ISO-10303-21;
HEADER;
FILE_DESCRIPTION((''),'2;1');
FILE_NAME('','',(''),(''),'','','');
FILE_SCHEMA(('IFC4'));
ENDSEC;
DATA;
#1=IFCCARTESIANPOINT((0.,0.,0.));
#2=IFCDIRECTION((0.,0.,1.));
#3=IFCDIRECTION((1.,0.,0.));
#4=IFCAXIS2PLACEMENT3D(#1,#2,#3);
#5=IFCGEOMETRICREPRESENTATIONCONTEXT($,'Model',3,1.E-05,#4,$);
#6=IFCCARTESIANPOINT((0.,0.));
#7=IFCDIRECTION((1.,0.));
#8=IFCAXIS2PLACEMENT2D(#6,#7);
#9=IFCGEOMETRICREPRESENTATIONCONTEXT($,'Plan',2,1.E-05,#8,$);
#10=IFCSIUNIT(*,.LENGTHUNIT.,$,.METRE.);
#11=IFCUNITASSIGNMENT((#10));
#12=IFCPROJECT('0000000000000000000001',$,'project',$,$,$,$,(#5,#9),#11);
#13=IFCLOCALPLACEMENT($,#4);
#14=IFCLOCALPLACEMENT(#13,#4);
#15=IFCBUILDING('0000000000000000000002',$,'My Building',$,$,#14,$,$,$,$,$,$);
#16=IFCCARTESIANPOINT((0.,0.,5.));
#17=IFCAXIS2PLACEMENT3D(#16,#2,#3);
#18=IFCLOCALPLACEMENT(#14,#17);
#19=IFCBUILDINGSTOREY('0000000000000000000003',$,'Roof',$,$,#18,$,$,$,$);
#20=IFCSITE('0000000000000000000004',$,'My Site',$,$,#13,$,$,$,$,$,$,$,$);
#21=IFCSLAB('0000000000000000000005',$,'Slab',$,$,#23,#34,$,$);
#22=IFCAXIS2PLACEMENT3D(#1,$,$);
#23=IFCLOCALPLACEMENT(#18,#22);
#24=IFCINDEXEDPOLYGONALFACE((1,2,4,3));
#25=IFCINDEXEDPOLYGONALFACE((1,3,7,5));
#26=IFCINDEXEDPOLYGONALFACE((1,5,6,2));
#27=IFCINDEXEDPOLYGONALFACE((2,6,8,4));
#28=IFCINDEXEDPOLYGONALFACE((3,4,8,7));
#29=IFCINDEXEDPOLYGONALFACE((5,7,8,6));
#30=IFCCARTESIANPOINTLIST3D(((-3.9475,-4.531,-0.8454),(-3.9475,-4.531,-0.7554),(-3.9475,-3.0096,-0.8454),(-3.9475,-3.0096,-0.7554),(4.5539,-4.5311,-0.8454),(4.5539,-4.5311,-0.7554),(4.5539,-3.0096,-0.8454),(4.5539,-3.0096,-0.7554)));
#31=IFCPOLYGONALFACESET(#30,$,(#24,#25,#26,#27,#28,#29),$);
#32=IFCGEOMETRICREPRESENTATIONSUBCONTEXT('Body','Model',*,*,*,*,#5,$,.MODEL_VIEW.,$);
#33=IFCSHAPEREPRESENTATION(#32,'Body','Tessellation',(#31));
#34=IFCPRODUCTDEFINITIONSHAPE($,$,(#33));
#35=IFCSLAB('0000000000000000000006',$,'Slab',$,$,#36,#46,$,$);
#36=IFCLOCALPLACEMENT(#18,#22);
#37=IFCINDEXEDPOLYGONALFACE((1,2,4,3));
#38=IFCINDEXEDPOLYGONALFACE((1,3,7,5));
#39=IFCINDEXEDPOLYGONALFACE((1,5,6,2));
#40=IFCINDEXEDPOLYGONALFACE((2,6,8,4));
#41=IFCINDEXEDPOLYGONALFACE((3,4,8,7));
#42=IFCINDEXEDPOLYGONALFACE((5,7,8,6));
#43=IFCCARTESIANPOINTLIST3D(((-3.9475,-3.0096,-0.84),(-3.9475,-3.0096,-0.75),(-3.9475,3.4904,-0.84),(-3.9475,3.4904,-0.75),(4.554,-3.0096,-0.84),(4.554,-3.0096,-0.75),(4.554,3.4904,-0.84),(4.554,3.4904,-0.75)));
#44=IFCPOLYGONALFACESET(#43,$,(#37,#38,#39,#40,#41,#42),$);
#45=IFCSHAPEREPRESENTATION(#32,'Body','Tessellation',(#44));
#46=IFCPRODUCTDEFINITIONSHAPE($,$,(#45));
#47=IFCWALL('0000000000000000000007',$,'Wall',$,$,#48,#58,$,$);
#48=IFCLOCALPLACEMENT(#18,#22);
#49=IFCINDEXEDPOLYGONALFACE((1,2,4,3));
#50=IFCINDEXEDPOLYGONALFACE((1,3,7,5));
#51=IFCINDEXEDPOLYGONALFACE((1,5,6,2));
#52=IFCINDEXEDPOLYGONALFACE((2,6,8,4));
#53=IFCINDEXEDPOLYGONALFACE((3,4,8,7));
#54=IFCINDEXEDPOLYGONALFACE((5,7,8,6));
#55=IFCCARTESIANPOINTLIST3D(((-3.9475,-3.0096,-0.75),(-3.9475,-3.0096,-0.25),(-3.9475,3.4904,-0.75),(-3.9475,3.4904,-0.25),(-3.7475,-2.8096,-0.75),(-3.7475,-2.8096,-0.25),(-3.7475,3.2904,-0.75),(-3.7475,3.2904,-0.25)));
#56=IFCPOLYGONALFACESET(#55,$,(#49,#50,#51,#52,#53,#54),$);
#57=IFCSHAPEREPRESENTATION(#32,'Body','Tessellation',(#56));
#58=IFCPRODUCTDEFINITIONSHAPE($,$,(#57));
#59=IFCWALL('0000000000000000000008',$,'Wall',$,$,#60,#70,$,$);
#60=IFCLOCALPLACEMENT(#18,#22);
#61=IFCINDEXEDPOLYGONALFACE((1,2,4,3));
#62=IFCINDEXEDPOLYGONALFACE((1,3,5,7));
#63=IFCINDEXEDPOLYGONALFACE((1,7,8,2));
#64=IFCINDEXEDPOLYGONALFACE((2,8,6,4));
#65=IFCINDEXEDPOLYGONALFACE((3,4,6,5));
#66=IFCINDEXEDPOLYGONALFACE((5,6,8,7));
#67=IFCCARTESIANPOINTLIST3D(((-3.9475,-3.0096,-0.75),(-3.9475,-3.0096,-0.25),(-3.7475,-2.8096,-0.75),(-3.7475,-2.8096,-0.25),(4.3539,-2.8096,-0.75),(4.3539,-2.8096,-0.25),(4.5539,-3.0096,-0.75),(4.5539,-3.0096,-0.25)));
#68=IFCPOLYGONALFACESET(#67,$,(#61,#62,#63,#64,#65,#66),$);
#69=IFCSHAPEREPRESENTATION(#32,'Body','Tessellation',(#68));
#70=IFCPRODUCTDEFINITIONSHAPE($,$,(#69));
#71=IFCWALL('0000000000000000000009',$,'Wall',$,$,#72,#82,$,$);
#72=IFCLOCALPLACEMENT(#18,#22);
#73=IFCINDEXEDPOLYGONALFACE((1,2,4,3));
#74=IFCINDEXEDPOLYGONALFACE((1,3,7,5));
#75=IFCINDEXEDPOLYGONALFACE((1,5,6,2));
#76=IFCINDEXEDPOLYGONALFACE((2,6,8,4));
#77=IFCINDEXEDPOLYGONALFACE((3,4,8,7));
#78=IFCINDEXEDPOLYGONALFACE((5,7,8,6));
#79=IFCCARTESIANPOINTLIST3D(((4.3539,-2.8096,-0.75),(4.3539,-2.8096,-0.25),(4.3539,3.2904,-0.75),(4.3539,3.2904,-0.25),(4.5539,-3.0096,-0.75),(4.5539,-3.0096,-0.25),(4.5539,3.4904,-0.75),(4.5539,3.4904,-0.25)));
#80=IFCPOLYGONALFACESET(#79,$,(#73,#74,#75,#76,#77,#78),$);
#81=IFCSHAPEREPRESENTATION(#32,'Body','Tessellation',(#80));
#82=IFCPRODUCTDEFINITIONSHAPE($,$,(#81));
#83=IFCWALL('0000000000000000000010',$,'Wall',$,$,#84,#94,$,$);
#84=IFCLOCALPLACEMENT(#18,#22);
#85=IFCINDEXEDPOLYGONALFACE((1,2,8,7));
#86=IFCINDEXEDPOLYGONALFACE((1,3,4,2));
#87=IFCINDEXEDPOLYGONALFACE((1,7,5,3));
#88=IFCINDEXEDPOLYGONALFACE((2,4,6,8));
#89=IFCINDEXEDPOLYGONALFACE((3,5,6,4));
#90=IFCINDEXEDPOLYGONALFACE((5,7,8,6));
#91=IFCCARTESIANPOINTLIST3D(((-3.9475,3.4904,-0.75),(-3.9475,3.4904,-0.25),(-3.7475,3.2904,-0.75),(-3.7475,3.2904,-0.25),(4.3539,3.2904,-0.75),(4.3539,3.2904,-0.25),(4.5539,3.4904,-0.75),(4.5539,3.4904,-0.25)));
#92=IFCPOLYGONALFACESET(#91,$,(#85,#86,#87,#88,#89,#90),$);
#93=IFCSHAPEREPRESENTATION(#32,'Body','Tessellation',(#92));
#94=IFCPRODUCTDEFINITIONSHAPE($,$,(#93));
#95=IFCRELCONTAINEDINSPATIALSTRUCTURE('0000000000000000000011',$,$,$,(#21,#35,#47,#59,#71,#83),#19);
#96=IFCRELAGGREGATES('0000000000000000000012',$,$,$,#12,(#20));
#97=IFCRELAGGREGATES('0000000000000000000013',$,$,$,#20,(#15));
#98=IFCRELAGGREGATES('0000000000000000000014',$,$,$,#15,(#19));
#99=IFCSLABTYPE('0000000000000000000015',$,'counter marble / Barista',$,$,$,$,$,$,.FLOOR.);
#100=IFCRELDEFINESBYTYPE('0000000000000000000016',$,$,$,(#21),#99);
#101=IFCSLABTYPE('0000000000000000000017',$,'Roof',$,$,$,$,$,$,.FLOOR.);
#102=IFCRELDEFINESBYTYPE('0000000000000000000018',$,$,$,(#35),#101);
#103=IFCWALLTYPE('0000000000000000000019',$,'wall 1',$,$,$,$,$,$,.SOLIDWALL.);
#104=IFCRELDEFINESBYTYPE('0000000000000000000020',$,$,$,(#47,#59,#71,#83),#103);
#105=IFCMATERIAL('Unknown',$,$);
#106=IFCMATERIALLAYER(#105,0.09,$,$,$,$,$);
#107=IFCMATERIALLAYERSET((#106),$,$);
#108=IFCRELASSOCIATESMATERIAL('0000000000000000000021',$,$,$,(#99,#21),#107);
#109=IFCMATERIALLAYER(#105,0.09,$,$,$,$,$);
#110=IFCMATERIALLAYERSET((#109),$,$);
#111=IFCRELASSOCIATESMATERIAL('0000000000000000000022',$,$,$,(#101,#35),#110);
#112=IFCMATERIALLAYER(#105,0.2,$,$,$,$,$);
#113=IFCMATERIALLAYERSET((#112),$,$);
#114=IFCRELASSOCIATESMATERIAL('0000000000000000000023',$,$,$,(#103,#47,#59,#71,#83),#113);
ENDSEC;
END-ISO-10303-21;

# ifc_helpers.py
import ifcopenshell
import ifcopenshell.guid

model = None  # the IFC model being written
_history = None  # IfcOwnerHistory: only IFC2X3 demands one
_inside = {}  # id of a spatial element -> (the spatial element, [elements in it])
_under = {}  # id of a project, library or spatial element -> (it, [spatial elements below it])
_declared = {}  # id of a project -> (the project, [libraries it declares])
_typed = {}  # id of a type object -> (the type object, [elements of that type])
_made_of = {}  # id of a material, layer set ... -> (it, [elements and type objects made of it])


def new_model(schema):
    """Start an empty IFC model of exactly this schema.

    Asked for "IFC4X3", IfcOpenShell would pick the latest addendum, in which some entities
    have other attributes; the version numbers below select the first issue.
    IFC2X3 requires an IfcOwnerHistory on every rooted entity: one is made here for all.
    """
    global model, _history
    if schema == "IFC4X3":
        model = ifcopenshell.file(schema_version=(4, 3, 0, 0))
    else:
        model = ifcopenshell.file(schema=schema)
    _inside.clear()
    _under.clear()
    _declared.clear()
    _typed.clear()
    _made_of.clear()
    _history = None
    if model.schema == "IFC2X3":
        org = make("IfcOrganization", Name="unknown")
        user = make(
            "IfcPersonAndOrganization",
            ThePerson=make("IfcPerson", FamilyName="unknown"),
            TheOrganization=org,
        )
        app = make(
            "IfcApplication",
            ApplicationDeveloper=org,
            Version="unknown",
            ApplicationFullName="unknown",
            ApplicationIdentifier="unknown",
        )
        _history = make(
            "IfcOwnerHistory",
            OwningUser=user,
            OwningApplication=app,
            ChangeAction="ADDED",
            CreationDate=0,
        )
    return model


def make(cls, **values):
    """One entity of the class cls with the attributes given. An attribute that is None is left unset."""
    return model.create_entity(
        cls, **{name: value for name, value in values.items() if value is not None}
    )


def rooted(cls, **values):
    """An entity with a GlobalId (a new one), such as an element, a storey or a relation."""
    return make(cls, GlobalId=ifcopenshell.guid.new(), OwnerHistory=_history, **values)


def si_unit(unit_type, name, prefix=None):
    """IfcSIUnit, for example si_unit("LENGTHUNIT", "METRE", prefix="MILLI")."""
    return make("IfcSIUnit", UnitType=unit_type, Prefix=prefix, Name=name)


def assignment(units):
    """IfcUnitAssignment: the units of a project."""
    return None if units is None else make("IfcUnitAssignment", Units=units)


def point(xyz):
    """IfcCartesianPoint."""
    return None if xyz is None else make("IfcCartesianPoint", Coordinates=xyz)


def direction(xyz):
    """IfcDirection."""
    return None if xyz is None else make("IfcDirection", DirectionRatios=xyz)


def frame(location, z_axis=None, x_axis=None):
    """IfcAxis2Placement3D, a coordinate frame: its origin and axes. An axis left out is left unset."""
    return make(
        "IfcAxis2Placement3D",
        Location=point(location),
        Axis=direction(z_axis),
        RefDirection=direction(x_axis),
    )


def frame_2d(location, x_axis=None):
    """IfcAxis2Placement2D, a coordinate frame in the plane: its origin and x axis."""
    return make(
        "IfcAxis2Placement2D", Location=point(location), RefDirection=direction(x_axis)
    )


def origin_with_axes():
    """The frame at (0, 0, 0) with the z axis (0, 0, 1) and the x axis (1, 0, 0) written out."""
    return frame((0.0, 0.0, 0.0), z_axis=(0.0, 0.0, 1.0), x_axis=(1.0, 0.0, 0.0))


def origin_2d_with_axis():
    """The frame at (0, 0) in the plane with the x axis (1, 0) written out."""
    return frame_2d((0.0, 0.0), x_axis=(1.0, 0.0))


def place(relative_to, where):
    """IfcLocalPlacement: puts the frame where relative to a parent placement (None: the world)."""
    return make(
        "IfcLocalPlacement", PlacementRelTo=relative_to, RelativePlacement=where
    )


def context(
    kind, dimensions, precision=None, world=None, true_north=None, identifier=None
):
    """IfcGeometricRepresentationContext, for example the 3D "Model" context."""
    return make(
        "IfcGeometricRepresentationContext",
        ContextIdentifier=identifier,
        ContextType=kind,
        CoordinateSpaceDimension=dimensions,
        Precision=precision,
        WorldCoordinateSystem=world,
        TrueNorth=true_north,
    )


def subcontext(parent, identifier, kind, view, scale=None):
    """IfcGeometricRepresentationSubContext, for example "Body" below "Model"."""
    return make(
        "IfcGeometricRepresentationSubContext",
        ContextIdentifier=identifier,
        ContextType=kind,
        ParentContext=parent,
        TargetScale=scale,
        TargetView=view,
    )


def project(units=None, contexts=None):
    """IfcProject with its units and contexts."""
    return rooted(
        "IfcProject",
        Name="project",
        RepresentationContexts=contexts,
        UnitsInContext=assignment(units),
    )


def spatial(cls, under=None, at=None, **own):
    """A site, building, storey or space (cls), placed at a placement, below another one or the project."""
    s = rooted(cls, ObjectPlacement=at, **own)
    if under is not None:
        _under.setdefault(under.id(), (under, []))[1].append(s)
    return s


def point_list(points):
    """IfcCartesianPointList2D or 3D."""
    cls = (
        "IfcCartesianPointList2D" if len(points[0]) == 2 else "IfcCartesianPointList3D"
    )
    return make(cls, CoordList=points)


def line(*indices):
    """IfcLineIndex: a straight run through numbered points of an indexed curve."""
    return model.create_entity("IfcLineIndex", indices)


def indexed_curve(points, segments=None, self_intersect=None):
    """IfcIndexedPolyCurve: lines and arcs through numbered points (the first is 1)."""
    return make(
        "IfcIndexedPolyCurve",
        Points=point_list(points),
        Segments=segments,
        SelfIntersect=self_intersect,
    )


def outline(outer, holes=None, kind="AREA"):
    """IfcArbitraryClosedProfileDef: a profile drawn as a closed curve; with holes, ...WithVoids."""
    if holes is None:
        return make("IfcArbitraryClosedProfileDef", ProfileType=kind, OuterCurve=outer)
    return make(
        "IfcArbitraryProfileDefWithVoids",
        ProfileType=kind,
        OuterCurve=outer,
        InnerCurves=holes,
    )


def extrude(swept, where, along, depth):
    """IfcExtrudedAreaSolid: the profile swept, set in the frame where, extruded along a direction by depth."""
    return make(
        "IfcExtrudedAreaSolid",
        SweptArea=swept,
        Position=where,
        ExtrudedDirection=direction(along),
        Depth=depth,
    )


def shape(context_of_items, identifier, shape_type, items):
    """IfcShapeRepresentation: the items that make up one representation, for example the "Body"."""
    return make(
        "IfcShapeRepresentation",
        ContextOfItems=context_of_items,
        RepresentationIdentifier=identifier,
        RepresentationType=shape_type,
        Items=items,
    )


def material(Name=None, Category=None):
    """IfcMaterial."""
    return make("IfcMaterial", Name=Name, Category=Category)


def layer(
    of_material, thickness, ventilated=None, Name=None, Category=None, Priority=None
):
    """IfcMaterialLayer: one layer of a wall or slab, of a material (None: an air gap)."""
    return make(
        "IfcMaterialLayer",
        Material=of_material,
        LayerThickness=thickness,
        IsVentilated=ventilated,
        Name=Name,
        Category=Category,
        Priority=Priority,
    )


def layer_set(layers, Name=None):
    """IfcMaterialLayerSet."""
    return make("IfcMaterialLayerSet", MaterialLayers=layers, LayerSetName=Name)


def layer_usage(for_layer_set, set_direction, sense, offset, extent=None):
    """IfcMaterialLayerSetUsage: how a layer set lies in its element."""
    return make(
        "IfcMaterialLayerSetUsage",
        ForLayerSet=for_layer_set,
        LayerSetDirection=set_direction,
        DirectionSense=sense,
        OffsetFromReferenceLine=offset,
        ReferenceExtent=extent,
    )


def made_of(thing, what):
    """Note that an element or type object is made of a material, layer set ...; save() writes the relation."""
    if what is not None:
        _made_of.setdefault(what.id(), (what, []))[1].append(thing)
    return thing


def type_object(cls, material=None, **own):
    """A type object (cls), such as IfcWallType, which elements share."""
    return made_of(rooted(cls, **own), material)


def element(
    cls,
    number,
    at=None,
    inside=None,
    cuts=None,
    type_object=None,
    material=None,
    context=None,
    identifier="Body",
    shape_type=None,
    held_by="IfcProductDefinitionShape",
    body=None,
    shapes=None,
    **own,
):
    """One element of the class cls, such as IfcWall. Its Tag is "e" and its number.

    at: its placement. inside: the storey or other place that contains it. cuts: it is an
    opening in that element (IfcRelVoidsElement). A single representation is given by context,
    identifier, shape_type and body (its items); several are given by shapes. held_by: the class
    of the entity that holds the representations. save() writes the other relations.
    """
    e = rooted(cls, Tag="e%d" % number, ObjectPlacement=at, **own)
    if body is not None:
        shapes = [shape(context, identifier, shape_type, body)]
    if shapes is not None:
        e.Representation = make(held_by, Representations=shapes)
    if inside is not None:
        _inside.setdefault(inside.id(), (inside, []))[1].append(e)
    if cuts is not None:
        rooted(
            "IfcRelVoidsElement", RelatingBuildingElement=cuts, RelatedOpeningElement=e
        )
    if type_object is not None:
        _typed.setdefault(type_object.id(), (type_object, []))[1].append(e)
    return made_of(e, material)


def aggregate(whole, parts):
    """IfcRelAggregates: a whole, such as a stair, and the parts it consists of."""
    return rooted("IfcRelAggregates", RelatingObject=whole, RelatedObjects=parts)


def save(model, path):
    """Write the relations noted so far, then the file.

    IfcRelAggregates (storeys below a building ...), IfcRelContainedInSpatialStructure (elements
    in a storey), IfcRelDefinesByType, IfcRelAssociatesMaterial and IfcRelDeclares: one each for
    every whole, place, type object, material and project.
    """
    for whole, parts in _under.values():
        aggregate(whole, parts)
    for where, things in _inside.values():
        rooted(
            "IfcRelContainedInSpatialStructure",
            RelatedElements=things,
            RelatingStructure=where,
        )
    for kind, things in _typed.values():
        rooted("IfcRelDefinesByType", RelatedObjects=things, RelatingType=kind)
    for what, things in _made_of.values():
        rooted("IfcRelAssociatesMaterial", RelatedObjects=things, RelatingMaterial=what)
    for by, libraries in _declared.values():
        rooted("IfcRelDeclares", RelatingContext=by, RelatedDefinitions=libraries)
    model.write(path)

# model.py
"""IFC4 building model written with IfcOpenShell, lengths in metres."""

from ifc_helpers import new_model, si_unit, frame, origin_with_axes, origin_2d_with_axis, place, context, subcontext, project, spatial, line, indexed_curve, outline, extrude, material, layer, layer_set, layer_usage, type_object, element, save


model = new_model("IFC4")

# Units and contexts
model_context = context("Model", 3, precision=1e-05, world=origin_with_axes())
plan_context = context("Plan", 2, precision=1e-05, world=origin_2d_with_axis())
body_context = subcontext(model_context, "Body", "Model", "MODEL_VIEW")
ifc_project = project(units=[si_unit("LENGTHUNIT", "METRE")], contexts=[model_context, plan_context])

# Site, building, storey
site_placement = place(None, origin_with_axes())
site = spatial("IfcSite", under=ifc_project, at=site_placement, Name="My Site")
building_placement = place(site_placement, origin_with_axes())
building = spatial("IfcBuilding", under=site, at=building_placement, Name="My Building")
storey_placement = place(building_placement, frame((0.0, 0.0, 5.0), z_axis=(0.0, 0.0, 1.0), x_axis=(1.0, 0.0, 0.0)))
storey = spatial("IfcBuildingStorey", under=building, at=storey_placement, Name="Roof")

# Slabs
ifc_material = material(Name="Unknown")
ifc_layer_1 = layer(ifc_material, 0.09)
ifc_layer_set_1 = layer_set([ifc_layer_1])
ifc_layer_usage_1 = layer_usage(ifc_layer_set_1, "AXIS3", "POSITIVE", -0.09)
slab_type_1 = type_object("IfcSlabType", Name="counter marble / Barista", PredefinedType="FLOOR", material=ifc_layer_set_1)
slab_1_placement = place(storey_placement, frame((-3.9475, -4.531, -0.7554), z_axis=(0.0, 0.0, 1.0), x_axis=(1.0, 0.0, 0.0)))
element("IfcSlab", 1, at=slab_1_placement, inside=storey, type_object=slab_type_1, material=ifc_layer_usage_1, Name="Slab", context=body_context, shape_type="SweptSolid", body=[
    extrude(outline(indexed_curve([(0.0, 0.0), (0.0, 1.5214), (8.5014, 1.5214), (8.5014, -0.0001), (0.0, 0.0)])), frame((0.0, 0.0, -0.09), z_axis=(0.0, 0.0, 1.0), x_axis=(1.0, 0.0, 0.0)), (0.0, 0.0, 1.0), 0.09),
])
ifc_layer_2 = layer(ifc_material, 0.09)
ifc_layer_set_2 = layer_set([ifc_layer_2])
ifc_layer_usage_2 = layer_usage(ifc_layer_set_2, "AXIS3", "POSITIVE", -0.09)
slab_type_2 = type_object("IfcSlabType", Name="Roof", PredefinedType="FLOOR", material=ifc_layer_set_2)
slab_2_placement = place(storey_placement, frame((-3.9475, 3.4904, -0.75), z_axis=(0.0, 0.0, 1.0), x_axis=(1.0, 0.0, 0.0)))
element("IfcSlab", 2, at=slab_2_placement, inside=storey, type_object=slab_type_2, material=ifc_layer_usage_2, Name="Slab", context=body_context, shape_type="SweptSolid", body=[
    extrude(outline(indexed_curve([(0.0, 0.0), (0.0, -6.5), (8.5015, -6.5), (8.5015, 0.0), (0.0, 0.0)])), frame((0.0, 0.0, -0.09), z_axis=(0.0, 0.0, 1.0), x_axis=(1.0, 0.0, 0.0)), (0.0, 0.0, 1.0), 0.09),
])

# Walls
ifc_layer_3 = layer(ifc_material, 0.2)
ifc_layer_set_3 = layer_set([ifc_layer_3])
ifc_layer_usage_3 = layer_usage(ifc_layer_set_3, "AXIS2", "POSITIVE", 0.0)
wall_type = type_object("IfcWallType", Name="wall 1", PredefinedType="SOLIDWALL", material=ifc_layer_set_3)
wall_1_placement = place(storey_placement, frame((-3.9475, 3.4904, -0.75), z_axis=(0.0, 0.0, 1.0), x_axis=(0.0, -1.0, 0.0)))
element("IfcWall", 3, at=wall_1_placement, inside=storey, type_object=wall_type, material=ifc_layer_usage_3, Name="Wall", context=body_context, shape_type="SweptSolid", body=[
    extrude(outline(indexed_curve([(0.0, 0.0), (0.2, 0.2), (6.3, 0.2), (6.5, 0.0)], segments=[line(1, 2, 3, 4, 1)])), origin_with_axes(), (0.0, 0.0, 1.0), 0.5),
])
ifc_layer_usage_4 = layer_usage(ifc_layer_set_3, "AXIS2", "POSITIVE", 0.0)
wall_2_placement = place(storey_placement, frame((-3.9475, -3.0096, -0.75), z_axis=(0.0, 0.0, 1.0), x_axis=(1.0, 0.0, 0.0)))
element("IfcWall", 4, at=wall_2_placement, inside=storey, type_object=wall_type, material=ifc_layer_usage_4, Name="Wall", context=body_context, shape_type="SweptSolid", body=[
    extrude(outline(indexed_curve([(0.0, 0.0), (0.2, 0.2), (8.3014, 0.2), (8.5014, 0.0)], segments=[line(1, 2, 3, 4, 1)])), origin_with_axes(), (0.0, 0.0, 1.0), 0.5),
])
ifc_layer_usage_5 = layer_usage(ifc_layer_set_3, "AXIS2", "POSITIVE", 0.0)
wall_3_placement = place(storey_placement, frame((4.5539, -3.0096, -0.75), z_axis=(0.0, 0.0, 1.0), x_axis=(0.0, 1.0, 0.0)))
element("IfcWall", 5, at=wall_3_placement, inside=storey, type_object=wall_type, material=ifc_layer_usage_5, Name="Wall", context=body_context, shape_type="SweptSolid", body=[
    extrude(outline(indexed_curve([(0.0, 0.0), (0.2, 0.2), (6.3, 0.2), (6.5, 0.0)], segments=[line(1, 2, 3, 4, 1)])), origin_with_axes(), (0.0, 0.0, 1.0), 0.5),
])
ifc_layer_usage_6 = layer_usage(ifc_layer_set_3, "AXIS2", "POSITIVE", 0.0)
wall_4_placement = place(storey_placement, frame((4.5539, 3.4904, -0.75), z_axis=(0.0, 0.0, 1.0), x_axis=(-1.0, 0.0, 0.0)))
element("IfcWall", 6, at=wall_4_placement, inside=storey, type_object=wall_type, material=ifc_layer_usage_6, Name="Wall", context=body_context, shape_type="SweptSolid", body=[
    extrude(outline(indexed_curve([(0.0, 0.0), (0.2, 0.2), (8.3014, 0.2), (8.5014, 0.0)], segments=[line(1, 2, 3, 4, 1)])), origin_with_axes(), (0.0, 0.0, 1.0), 0.5),
])

save(model, "model.ifc")
